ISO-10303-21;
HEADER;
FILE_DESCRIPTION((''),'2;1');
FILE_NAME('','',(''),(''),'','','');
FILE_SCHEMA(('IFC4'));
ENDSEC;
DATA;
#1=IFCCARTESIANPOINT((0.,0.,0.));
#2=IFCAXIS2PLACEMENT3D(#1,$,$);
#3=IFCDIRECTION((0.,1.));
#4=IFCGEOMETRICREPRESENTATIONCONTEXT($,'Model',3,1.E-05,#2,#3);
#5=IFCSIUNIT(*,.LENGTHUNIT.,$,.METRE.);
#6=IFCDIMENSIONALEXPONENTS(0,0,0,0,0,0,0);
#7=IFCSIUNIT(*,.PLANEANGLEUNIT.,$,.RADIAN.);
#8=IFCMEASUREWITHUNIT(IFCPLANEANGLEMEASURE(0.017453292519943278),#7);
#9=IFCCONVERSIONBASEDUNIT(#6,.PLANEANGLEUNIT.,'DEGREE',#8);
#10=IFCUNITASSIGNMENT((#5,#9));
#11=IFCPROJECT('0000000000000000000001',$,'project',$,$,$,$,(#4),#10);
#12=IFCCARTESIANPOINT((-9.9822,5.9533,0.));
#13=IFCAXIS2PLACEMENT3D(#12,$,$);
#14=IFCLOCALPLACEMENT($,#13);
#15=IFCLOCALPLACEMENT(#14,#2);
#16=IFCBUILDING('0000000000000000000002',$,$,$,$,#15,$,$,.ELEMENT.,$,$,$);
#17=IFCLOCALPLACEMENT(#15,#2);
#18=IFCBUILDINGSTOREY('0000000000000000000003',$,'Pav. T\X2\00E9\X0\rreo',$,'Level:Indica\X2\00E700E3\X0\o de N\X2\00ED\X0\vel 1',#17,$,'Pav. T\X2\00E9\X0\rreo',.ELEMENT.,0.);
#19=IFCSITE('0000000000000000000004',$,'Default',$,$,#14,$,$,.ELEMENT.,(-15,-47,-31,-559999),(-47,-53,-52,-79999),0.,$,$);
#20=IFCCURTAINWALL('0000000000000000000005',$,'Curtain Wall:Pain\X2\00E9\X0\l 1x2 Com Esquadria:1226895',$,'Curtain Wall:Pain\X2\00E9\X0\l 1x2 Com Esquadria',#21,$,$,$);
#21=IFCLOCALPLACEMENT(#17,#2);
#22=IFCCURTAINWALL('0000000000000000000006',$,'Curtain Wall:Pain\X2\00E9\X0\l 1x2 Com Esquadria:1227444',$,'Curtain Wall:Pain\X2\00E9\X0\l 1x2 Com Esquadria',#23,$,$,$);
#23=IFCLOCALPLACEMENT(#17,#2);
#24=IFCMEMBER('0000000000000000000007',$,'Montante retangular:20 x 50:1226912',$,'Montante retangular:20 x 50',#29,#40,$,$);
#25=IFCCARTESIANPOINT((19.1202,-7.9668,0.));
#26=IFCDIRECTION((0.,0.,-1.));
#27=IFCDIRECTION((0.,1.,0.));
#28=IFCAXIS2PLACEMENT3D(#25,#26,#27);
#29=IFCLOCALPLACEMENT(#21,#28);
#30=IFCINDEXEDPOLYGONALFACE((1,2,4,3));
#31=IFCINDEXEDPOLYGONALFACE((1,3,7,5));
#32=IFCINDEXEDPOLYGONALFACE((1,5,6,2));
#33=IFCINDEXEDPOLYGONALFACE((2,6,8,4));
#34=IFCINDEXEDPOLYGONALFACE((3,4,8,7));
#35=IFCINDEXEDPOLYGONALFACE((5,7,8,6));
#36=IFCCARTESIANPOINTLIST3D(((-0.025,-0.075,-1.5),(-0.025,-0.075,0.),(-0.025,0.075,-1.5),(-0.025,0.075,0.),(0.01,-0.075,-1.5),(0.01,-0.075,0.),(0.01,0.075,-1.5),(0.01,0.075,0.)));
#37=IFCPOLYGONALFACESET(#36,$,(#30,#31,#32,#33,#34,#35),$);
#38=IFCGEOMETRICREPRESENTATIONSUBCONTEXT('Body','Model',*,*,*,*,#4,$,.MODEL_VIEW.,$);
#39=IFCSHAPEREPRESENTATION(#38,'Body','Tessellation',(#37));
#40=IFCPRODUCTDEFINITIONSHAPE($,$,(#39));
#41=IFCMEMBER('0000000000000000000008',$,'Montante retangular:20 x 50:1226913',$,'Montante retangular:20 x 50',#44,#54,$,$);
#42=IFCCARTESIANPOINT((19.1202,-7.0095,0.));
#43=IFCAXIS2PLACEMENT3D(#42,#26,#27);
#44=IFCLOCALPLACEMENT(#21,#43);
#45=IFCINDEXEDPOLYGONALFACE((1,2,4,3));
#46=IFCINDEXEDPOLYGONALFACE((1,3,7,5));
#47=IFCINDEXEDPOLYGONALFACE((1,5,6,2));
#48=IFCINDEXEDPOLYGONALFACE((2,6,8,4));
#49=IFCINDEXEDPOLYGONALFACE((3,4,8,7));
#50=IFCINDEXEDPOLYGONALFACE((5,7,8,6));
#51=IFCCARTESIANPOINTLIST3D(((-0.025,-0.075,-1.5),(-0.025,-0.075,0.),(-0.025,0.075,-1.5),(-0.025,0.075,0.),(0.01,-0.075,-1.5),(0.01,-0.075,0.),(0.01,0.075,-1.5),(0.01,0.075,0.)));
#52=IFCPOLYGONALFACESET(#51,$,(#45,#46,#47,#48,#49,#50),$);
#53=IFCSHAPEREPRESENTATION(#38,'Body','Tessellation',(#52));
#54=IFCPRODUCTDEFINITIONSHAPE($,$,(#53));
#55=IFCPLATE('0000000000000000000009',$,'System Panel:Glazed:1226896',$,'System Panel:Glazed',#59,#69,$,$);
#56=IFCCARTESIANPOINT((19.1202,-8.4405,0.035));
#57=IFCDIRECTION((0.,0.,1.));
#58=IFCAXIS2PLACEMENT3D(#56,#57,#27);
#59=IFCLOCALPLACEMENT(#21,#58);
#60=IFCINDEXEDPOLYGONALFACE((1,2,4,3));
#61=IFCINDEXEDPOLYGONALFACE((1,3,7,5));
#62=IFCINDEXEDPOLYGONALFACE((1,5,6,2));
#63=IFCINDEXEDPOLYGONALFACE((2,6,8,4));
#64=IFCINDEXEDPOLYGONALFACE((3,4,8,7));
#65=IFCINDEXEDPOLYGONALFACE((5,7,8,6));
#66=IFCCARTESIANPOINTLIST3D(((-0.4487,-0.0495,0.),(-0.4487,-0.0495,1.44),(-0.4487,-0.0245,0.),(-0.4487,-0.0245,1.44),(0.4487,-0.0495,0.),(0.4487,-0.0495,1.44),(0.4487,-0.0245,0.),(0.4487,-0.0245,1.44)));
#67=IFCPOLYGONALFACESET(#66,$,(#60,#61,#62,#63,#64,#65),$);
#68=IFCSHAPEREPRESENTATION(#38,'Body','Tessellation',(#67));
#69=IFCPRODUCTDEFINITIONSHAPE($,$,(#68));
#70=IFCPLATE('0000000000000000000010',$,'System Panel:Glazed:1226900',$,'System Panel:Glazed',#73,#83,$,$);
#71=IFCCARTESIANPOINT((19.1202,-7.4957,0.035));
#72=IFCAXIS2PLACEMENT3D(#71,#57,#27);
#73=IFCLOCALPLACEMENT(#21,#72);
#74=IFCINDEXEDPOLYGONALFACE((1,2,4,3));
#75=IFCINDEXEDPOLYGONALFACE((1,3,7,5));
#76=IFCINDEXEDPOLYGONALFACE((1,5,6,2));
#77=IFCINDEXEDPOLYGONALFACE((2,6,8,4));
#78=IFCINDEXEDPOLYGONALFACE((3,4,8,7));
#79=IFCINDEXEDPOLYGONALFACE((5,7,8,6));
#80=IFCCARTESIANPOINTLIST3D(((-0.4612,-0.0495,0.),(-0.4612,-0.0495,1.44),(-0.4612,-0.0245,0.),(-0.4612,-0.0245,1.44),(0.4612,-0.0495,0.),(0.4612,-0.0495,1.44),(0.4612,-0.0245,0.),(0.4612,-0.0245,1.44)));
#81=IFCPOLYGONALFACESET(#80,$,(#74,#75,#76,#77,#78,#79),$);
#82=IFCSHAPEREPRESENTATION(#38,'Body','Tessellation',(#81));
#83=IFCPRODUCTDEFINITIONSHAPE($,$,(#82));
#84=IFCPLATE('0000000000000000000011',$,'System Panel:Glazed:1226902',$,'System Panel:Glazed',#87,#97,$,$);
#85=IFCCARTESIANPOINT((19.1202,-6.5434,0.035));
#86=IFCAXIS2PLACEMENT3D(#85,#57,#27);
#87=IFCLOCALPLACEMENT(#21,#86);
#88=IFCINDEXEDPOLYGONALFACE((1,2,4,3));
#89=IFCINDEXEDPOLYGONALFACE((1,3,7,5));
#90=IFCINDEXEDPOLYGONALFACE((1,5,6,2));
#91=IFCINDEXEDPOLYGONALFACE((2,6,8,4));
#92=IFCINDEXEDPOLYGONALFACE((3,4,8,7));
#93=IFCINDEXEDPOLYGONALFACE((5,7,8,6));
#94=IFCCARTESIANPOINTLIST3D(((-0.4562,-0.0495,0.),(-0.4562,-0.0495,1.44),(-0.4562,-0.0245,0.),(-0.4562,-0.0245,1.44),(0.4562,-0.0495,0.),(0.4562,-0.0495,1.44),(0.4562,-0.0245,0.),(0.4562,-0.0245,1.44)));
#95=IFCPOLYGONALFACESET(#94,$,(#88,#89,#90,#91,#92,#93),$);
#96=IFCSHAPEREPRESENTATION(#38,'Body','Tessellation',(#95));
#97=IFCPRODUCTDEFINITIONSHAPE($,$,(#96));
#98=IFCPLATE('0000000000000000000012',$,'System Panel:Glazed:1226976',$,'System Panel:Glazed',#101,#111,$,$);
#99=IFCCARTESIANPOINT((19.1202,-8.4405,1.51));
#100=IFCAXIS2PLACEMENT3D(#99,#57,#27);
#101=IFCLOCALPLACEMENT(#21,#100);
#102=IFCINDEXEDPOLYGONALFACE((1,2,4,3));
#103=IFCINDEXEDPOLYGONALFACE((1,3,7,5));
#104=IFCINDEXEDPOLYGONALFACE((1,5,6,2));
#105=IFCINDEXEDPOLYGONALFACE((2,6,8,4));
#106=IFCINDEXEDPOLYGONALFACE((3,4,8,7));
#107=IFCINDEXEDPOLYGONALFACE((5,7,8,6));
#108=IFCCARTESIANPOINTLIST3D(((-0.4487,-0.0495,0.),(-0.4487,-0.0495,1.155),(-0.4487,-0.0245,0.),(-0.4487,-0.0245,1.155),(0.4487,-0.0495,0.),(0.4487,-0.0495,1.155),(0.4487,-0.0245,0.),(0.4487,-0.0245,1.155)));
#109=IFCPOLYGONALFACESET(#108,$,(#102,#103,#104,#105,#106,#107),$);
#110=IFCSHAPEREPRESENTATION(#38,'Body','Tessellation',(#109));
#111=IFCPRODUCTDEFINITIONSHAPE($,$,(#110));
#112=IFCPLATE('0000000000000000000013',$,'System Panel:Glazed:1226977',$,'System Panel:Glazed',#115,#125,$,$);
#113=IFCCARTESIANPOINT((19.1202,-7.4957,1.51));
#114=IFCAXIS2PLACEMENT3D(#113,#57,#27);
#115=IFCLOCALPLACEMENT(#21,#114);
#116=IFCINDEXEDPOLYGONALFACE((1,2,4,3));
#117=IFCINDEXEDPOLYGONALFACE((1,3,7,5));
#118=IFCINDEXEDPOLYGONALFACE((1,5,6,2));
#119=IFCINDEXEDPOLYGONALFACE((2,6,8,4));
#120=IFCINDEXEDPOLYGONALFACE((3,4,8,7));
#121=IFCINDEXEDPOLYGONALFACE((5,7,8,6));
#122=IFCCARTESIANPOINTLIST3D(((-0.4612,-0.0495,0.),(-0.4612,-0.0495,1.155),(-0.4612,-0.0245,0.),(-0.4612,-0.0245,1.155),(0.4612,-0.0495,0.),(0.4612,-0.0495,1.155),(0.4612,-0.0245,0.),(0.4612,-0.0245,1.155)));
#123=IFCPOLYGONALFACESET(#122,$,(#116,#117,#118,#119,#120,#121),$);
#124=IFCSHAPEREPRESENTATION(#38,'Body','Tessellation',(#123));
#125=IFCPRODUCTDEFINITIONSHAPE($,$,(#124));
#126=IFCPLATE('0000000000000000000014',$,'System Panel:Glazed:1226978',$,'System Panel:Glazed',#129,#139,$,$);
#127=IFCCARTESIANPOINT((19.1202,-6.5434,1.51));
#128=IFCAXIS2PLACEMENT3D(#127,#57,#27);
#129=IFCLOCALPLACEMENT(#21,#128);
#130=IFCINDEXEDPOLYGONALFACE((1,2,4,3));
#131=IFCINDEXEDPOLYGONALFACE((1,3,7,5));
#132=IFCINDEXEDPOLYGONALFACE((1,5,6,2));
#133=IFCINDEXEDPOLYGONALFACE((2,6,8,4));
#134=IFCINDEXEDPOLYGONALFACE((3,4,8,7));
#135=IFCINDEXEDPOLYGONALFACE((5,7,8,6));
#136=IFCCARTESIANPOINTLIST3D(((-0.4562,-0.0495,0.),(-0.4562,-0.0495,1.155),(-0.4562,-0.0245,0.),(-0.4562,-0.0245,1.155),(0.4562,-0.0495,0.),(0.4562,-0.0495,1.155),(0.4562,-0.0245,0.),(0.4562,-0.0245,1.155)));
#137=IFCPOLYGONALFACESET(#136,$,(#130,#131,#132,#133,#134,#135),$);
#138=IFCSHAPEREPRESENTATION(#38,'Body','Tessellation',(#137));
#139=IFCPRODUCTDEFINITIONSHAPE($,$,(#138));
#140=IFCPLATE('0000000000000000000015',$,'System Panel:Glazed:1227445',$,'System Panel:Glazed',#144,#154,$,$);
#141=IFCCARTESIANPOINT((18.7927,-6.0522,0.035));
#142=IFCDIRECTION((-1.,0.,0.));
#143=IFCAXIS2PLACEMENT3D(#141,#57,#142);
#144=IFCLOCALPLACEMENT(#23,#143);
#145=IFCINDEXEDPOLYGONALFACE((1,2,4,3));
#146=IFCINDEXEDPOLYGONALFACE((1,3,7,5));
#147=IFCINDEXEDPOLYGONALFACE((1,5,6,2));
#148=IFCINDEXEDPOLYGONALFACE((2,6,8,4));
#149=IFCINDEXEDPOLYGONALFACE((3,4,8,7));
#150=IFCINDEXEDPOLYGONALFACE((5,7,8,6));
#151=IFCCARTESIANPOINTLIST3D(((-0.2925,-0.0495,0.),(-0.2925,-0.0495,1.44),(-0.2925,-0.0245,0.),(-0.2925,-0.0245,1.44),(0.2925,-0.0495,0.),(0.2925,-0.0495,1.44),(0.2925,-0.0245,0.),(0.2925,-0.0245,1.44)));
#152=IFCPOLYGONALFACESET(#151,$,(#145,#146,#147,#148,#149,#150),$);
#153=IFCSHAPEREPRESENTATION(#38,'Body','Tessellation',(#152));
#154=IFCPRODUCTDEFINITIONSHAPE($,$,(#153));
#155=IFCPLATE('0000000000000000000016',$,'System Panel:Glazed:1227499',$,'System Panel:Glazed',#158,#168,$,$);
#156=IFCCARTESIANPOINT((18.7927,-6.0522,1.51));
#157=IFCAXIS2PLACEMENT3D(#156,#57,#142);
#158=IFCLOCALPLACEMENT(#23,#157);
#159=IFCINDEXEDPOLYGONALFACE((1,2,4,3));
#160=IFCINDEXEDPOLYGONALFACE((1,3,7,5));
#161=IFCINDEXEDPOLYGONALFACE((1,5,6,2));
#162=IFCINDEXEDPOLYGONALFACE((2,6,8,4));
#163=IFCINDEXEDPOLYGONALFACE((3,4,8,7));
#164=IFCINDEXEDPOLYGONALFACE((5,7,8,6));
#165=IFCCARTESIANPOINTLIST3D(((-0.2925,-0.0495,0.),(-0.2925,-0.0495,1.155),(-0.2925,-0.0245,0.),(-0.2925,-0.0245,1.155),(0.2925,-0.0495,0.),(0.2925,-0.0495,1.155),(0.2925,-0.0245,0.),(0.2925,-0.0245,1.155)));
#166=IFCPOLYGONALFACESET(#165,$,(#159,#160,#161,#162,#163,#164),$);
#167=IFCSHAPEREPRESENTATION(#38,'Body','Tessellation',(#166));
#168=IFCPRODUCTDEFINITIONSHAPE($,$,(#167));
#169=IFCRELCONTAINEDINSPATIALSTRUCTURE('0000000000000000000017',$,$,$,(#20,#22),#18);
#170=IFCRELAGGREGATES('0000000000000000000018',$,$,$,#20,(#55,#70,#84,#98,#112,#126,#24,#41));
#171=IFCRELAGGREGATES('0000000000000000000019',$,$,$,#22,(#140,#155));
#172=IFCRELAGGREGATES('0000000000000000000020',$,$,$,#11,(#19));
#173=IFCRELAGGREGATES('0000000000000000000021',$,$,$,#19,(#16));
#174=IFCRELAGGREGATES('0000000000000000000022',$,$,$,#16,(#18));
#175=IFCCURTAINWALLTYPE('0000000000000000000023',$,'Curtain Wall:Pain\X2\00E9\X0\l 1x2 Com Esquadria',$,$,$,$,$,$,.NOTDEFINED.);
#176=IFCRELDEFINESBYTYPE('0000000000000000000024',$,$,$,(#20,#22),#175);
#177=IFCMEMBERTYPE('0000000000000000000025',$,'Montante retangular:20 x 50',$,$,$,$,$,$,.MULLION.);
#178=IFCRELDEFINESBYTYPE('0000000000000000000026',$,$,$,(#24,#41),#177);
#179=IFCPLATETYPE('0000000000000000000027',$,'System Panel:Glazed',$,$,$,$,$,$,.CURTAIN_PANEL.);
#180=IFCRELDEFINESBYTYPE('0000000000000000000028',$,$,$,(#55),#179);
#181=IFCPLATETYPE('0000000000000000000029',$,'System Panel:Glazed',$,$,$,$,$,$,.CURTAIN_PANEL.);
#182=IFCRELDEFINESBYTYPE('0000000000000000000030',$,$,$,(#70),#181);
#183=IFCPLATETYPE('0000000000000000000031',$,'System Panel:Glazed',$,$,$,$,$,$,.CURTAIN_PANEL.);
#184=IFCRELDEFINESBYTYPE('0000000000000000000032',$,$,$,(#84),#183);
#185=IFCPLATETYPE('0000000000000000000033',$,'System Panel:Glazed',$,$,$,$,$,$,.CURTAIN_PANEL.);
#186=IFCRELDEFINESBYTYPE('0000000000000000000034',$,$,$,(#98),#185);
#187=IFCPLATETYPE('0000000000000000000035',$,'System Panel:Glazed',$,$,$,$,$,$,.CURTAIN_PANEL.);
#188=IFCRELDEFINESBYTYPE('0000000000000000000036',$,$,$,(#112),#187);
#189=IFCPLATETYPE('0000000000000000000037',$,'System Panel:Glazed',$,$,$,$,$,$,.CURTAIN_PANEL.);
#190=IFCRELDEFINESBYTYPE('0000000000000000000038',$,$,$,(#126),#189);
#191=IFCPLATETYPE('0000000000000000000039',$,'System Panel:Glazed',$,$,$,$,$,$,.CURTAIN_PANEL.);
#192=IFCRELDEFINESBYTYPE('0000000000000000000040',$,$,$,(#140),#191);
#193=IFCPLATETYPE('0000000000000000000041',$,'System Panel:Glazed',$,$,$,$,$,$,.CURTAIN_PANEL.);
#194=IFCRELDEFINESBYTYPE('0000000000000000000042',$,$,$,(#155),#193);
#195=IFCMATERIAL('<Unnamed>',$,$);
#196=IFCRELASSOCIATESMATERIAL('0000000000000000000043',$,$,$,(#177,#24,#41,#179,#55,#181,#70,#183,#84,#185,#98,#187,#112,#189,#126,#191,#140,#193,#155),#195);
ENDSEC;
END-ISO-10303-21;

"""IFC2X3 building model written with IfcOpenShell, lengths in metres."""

from ifc_helpers import new_model, entity, si_unit, converted_unit, direction, frame, frame_2d, origin, origin_2d_with_axis, place, context, subcontext, project, spatial, rectangle, extrude, source, transform, mapped, material, type_object, type_shapes, element, aggregate, save


model = new_model("IFC2X3")

# Units and contexts
model_context = context("Model", 3, precision=1e-05, world=origin(), true_north=direction((0.0, 1.0)))
body_context = subcontext(model_context, "Body", "Model", "MODEL_VIEW")
ifc_project = project(units=[si_unit("LENGTHUNIT", "METRE"), converted_unit("PLANEANGLEUNIT", "DEGREE", entity("IfcPlaneAngleMeasure", 0.017453292519943278), si_unit("PLANEANGLEUNIT", "RADIAN"), dimensions=[0, 0, 0, 0, 0, 0, 0])], contexts=[model_context])

# Site, building, storey
site_placement = place(None, frame((-9.9822, 5.9533, 0.0)))
site = spatial("IfcSite", under=ifc_project, at=site_placement, Name="Default", CompositionType="ELEMENT", RefLatitude=(-15, -47, -31, -559999), RefLongitude=(-47, -53, -52, -79999), RefElevation=0.0)
building_placement = place(site_placement, origin())
building = spatial("IfcBuilding", under=site, at=building_placement, CompositionType="ELEMENT")
storey_placement = place(building_placement, origin())
storey = spatial("IfcBuildingStorey", under=building, at=storey_placement, Name="Pav. Térreo", ObjectType="Level:Indicação de Nível 1", LongName="Pav. Térreo", CompositionType="ELEMENT", Elevation=0.0)

# Curtain wall
curtain_wall_type = type_object("IfcCurtainWallType", Name="Curtain Wall:Painél 1x2 Com Esquadria", PredefinedType="NOTDEFINED")
curtain_wall_1_placement = place(storey_placement, origin())
curtain_wall_1 = element("IfcCurtainWall", 1, at=curtain_wall_1_placement, inside=storey, type_object=curtain_wall_type, Name="Curtain Wall:Painél 1x2 Com Esquadria:1226895", ObjectType="Curtain Wall:Painél 1x2 Com Esquadria")
ifc_material_1 = material(Name="<Unnamed>")

# Curtain wall
curtain_wall_2_placement = place(storey_placement, origin())
curtain_wall_2 = element("IfcCurtainWall", 2, at=curtain_wall_2_placement, inside=storey, type_object=curtain_wall_type, Name="Curtain Wall:Painél 1x2 Com Esquadria:1227444", ObjectType="Curtain Wall:Painél 1x2 Com Esquadria")

# Members
member_type_1 = type_object("IfcMemberType", Name="Montante retangular:20 x 50", PredefinedType="MULLION", material=ifc_material_1)
shared_shape_1 = source(origin(), body_context, "Body", "SweptSolid", [
    extrude(rectangle(XDim=0.035, YDim=0.15, at=origin_2d_with_axis()), frame((-0.0075, 0.0, -1.5), z_axis=(0.0, 0.0, 1.0), x_axis=(-1.0, 0.0, 0.0)), (0.0, 0.0, 1.0), 1.5),
])
type_shapes(member_type_1, [shared_shape_1])
member_1_placement = place(curtain_wall_1_placement, frame((19.1202, -7.9668, 0.0), z_axis=(0.0, 0.0, -1.0), x_axis=(0.0, 1.0, 0.0)))
member_1 = element("IfcMember", 3, at=member_1_placement, type_object=member_type_1, material=ifc_material_1, Name="Montante retangular:20 x 50:1226912", ObjectType="Montante retangular:20 x 50", context=body_context, shape_type="MappedRepresentation", body=[
    mapped(shared_shape_1, transform((0.0, 0.0, 0.0), scale=1.0)),
])
member_2_placement = place(curtain_wall_1_placement, frame((19.1202, -7.0095, 0.0), z_axis=(0.0, 0.0, -1.0), x_axis=(0.0, 1.0, 0.0)))
member_2 = element("IfcMember", 4, at=member_2_placement, type_object=member_type_1, material=ifc_material_1, Name="Montante retangular:20 x 50:1226913", ObjectType="Montante retangular:20 x 50", context=body_context, shape_type="MappedRepresentation", body=[
    mapped(shared_shape_1, transform((0.0, 0.0, 0.0), scale=1.0)),
])

# Plates
plate_type_1 = type_object("IfcPlateType", Name="System Panel:Glazed", PredefinedType="CURTAIN_PANEL", material=ifc_material_1)
shared_shape_2 = source(origin(), body_context, "Body", "SweptSolid", [
    extrude(rectangle(XDim=0.025, YDim=0.8973, at=frame_2d((0.0, 0.0), x_axis=(1.0, 0.0))), frame((0.0, -0.037, 0.0), z_axis=(0.0, 0.0, 1.0), x_axis=(0.0, 1.0, 0.0)), (0.0, 0.0, 1.0), 1.44),
])
type_shapes(plate_type_1, [shared_shape_2])
plate_1_placement = place(curtain_wall_1_placement, frame((19.1202, -8.4405, 0.035), z_axis=(0.0, 0.0, 1.0), x_axis=(0.0, 1.0, 0.0)))
plate_1 = element("IfcPlate", 5, at=plate_1_placement, type_object=plate_type_1, material=ifc_material_1, Name="System Panel:Glazed:1226896", ObjectType="System Panel:Glazed", context=body_context, shape_type="MappedRepresentation", body=[
    mapped(shared_shape_2, transform((0.0, 0.0, 0.0), scale=1.0)),
])
plate_type_2 = type_object("IfcPlateType", Name="System Panel:Glazed", PredefinedType="CURTAIN_PANEL", material=ifc_material_1)
shared_shape_3 = source(origin(), body_context, "Body", "SweptSolid", [
    extrude(rectangle(XDim=0.025, YDim=0.9223, at=origin_2d_with_axis()), frame((0.0, -0.037, 0.0), z_axis=(0.0, 0.0, 1.0), x_axis=(0.0, 1.0, 0.0)), (0.0, 0.0, 1.0), 1.44),
])
type_shapes(plate_type_2, [shared_shape_3])
plate_2_placement = place(curtain_wall_1_placement, frame((19.1202, -7.4957, 0.035), z_axis=(0.0, 0.0, 1.0), x_axis=(0.0, 1.0, 0.0)))
plate_2 = element("IfcPlate", 6, at=plate_2_placement, type_object=plate_type_2, material=ifc_material_1, Name="System Panel:Glazed:1226900", ObjectType="System Panel:Glazed", context=body_context, shape_type="MappedRepresentation", body=[
    mapped(shared_shape_3, transform((0.0, 0.0, 0.0), scale=1.0)),
])
plate_type_3 = type_object("IfcPlateType", Name="System Panel:Glazed", PredefinedType="CURTAIN_PANEL", material=ifc_material_1)
shared_shape_4 = source(origin(), body_context, "Body", "SweptSolid", [
    extrude(rectangle(XDim=0.025, YDim=0.9123, at=origin_2d_with_axis()), frame((0.0, -0.037, 0.0), z_axis=(0.0, 0.0, 1.0), x_axis=(0.0, 1.0, 0.0)), (0.0, 0.0, 1.0), 1.44),
])
type_shapes(plate_type_3, [shared_shape_4])
plate_3_placement = place(curtain_wall_1_placement, frame((19.1202, -6.5434, 0.035), z_axis=(0.0, 0.0, 1.0), x_axis=(0.0, 1.0, 0.0)))
plate_3 = element("IfcPlate", 7, at=plate_3_placement, type_object=plate_type_3, material=ifc_material_1, Name="System Panel:Glazed:1226902", ObjectType="System Panel:Glazed", context=body_context, shape_type="MappedRepresentation", body=[
    mapped(shared_shape_4, transform((0.0, 0.0, 0.0), scale=1.0)),
])
plate_type_4 = type_object("IfcPlateType", Name="System Panel:Glazed", PredefinedType="CURTAIN_PANEL", material=ifc_material_1)
shared_shape_5 = source(origin(), body_context, "Body", "SweptSolid", [
    extrude(rectangle(XDim=0.025, YDim=0.8973, at=frame_2d((0.0, 0.0), x_axis=(1.0, 0.0))), frame((0.0, -0.037, 0.0), z_axis=(0.0, 0.0, 1.0), x_axis=(0.0, 1.0, 0.0)), (0.0, 0.0, 1.0), 1.155),
])
type_shapes(plate_type_4, [shared_shape_5])
plate_4_placement = place(curtain_wall_1_placement, frame((19.1202, -8.4405, 1.51), z_axis=(0.0, 0.0, 1.0), x_axis=(0.0, 1.0, 0.0)))
plate_4 = element("IfcPlate", 8, at=plate_4_placement, type_object=plate_type_4, material=ifc_material_1, Name="System Panel:Glazed:1226976", ObjectType="System Panel:Glazed", context=body_context, shape_type="MappedRepresentation", body=[
    mapped(shared_shape_5, transform((0.0, 0.0, 0.0), scale=1.0)),
])
plate_type_5 = type_object("IfcPlateType", Name="System Panel:Glazed", PredefinedType="CURTAIN_PANEL", material=ifc_material_1)
shared_shape_6 = source(origin(), body_context, "Body", "SweptSolid", [
    extrude(rectangle(XDim=0.025, YDim=0.9223, at=origin_2d_with_axis()), frame((0.0, -0.037, 0.0), z_axis=(0.0, 0.0, 1.0), x_axis=(0.0, 1.0, 0.0)), (0.0, 0.0, 1.0), 1.155),
])
type_shapes(plate_type_5, [shared_shape_6])
plate_5_placement = place(curtain_wall_1_placement, frame((19.1202, -7.4957, 1.51), z_axis=(0.0, 0.0, 1.0), x_axis=(0.0, 1.0, 0.0)))
plate_5 = element("IfcPlate", 9, at=plate_5_placement, type_object=plate_type_5, material=ifc_material_1, Name="System Panel:Glazed:1226977", ObjectType="System Panel:Glazed", context=body_context, shape_type="MappedRepresentation", body=[
    mapped(shared_shape_6, transform((0.0, 0.0, 0.0), scale=1.0)),
])
plate_type_6 = type_object("IfcPlateType", Name="System Panel:Glazed", PredefinedType="CURTAIN_PANEL", material=ifc_material_1)
shared_shape_7 = source(origin(), body_context, "Body", "SweptSolid", [
    extrude(rectangle(XDim=0.025, YDim=0.9123, at=origin_2d_with_axis()), frame((0.0, -0.037, 0.0), z_axis=(0.0, 0.0, 1.0), x_axis=(0.0, 1.0, 0.0)), (0.0, 0.0, 1.0), 1.155),
])
type_shapes(plate_type_6, [shared_shape_7])
plate_6_placement = place(curtain_wall_1_placement, frame((19.1202, -6.5434, 1.51), z_axis=(0.0, 0.0, 1.0), x_axis=(0.0, 1.0, 0.0)))
plate_6 = element("IfcPlate", 10, at=plate_6_placement, type_object=plate_type_6, material=ifc_material_1, Name="System Panel:Glazed:1226978", ObjectType="System Panel:Glazed", context=body_context, shape_type="MappedRepresentation", body=[
    mapped(shared_shape_7, transform((0.0, 0.0, 0.0), scale=1.0)),
])
aggregate(curtain_wall_1, [plate_1, plate_2, plate_3, plate_4, plate_5, plate_6, member_1, member_2])
plate_type_7 = type_object("IfcPlateType", Name="System Panel:Glazed", PredefinedType="CURTAIN_PANEL", material=ifc_material_1)
shared_shape_8 = source(origin(), body_context, "Body", "SweptSolid", [
    extrude(rectangle(XDim=0.025, YDim=0.585, at=frame_2d((0.0, 0.0), x_axis=(1.0, 0.0))), frame((0.0, -0.037, 0.0), z_axis=(0.0, 0.0, 1.0), x_axis=(0.0, 1.0, 0.0)), (0.0, 0.0, 1.0), 1.44),
])
type_shapes(plate_type_7, [shared_shape_8])
plate_7_placement = place(curtain_wall_2_placement, frame((18.7927, -6.0522, 0.035), z_axis=(0.0, 0.0, 1.0), x_axis=(-1.0, 0.0, 0.0)))
plate_7 = element("IfcPlate", 11, at=plate_7_placement, type_object=plate_type_7, material=ifc_material_1, Name="System Panel:Glazed:1227445", ObjectType="System Panel:Glazed", context=body_context, shape_type="MappedRepresentation", body=[
    mapped(shared_shape_8, transform((0.0, 0.0, 0.0), scale=1.0)),
])
plate_type_8 = type_object("IfcPlateType", Name="System Panel:Glazed", PredefinedType="CURTAIN_PANEL", material=ifc_material_1)
shared_shape_9 = source(origin(), body_context, "Body", "SweptSolid", [
    extrude(rectangle(XDim=0.025, YDim=0.585, at=frame_2d((0.0, 0.0), x_axis=(1.0, 0.0))), frame((0.0, -0.037, 0.0), z_axis=(0.0, 0.0, 1.0), x_axis=(0.0, 1.0, 0.0)), (0.0, 0.0, 1.0), 1.155),
])
type_shapes(plate_type_8, [shared_shape_9])
plate_8_placement = place(curtain_wall_2_placement, frame((18.7927, -6.0522, 1.51), z_axis=(0.0, 0.0, 1.0), x_axis=(-1.0, 0.0, 0.0)))
plate_8 = element("IfcPlate", 12, at=plate_8_placement, type_object=plate_type_8, material=ifc_material_1, Name="System Panel:Glazed:1227499", ObjectType="System Panel:Glazed", context=body_context, shape_type="MappedRepresentation", body=[
    mapped(shared_shape_9, transform((0.0, 0.0, 0.0), scale=1.0)),
])
aggregate(curtain_wall_2, [plate_7, plate_8])

save(model, "model.ifc")
